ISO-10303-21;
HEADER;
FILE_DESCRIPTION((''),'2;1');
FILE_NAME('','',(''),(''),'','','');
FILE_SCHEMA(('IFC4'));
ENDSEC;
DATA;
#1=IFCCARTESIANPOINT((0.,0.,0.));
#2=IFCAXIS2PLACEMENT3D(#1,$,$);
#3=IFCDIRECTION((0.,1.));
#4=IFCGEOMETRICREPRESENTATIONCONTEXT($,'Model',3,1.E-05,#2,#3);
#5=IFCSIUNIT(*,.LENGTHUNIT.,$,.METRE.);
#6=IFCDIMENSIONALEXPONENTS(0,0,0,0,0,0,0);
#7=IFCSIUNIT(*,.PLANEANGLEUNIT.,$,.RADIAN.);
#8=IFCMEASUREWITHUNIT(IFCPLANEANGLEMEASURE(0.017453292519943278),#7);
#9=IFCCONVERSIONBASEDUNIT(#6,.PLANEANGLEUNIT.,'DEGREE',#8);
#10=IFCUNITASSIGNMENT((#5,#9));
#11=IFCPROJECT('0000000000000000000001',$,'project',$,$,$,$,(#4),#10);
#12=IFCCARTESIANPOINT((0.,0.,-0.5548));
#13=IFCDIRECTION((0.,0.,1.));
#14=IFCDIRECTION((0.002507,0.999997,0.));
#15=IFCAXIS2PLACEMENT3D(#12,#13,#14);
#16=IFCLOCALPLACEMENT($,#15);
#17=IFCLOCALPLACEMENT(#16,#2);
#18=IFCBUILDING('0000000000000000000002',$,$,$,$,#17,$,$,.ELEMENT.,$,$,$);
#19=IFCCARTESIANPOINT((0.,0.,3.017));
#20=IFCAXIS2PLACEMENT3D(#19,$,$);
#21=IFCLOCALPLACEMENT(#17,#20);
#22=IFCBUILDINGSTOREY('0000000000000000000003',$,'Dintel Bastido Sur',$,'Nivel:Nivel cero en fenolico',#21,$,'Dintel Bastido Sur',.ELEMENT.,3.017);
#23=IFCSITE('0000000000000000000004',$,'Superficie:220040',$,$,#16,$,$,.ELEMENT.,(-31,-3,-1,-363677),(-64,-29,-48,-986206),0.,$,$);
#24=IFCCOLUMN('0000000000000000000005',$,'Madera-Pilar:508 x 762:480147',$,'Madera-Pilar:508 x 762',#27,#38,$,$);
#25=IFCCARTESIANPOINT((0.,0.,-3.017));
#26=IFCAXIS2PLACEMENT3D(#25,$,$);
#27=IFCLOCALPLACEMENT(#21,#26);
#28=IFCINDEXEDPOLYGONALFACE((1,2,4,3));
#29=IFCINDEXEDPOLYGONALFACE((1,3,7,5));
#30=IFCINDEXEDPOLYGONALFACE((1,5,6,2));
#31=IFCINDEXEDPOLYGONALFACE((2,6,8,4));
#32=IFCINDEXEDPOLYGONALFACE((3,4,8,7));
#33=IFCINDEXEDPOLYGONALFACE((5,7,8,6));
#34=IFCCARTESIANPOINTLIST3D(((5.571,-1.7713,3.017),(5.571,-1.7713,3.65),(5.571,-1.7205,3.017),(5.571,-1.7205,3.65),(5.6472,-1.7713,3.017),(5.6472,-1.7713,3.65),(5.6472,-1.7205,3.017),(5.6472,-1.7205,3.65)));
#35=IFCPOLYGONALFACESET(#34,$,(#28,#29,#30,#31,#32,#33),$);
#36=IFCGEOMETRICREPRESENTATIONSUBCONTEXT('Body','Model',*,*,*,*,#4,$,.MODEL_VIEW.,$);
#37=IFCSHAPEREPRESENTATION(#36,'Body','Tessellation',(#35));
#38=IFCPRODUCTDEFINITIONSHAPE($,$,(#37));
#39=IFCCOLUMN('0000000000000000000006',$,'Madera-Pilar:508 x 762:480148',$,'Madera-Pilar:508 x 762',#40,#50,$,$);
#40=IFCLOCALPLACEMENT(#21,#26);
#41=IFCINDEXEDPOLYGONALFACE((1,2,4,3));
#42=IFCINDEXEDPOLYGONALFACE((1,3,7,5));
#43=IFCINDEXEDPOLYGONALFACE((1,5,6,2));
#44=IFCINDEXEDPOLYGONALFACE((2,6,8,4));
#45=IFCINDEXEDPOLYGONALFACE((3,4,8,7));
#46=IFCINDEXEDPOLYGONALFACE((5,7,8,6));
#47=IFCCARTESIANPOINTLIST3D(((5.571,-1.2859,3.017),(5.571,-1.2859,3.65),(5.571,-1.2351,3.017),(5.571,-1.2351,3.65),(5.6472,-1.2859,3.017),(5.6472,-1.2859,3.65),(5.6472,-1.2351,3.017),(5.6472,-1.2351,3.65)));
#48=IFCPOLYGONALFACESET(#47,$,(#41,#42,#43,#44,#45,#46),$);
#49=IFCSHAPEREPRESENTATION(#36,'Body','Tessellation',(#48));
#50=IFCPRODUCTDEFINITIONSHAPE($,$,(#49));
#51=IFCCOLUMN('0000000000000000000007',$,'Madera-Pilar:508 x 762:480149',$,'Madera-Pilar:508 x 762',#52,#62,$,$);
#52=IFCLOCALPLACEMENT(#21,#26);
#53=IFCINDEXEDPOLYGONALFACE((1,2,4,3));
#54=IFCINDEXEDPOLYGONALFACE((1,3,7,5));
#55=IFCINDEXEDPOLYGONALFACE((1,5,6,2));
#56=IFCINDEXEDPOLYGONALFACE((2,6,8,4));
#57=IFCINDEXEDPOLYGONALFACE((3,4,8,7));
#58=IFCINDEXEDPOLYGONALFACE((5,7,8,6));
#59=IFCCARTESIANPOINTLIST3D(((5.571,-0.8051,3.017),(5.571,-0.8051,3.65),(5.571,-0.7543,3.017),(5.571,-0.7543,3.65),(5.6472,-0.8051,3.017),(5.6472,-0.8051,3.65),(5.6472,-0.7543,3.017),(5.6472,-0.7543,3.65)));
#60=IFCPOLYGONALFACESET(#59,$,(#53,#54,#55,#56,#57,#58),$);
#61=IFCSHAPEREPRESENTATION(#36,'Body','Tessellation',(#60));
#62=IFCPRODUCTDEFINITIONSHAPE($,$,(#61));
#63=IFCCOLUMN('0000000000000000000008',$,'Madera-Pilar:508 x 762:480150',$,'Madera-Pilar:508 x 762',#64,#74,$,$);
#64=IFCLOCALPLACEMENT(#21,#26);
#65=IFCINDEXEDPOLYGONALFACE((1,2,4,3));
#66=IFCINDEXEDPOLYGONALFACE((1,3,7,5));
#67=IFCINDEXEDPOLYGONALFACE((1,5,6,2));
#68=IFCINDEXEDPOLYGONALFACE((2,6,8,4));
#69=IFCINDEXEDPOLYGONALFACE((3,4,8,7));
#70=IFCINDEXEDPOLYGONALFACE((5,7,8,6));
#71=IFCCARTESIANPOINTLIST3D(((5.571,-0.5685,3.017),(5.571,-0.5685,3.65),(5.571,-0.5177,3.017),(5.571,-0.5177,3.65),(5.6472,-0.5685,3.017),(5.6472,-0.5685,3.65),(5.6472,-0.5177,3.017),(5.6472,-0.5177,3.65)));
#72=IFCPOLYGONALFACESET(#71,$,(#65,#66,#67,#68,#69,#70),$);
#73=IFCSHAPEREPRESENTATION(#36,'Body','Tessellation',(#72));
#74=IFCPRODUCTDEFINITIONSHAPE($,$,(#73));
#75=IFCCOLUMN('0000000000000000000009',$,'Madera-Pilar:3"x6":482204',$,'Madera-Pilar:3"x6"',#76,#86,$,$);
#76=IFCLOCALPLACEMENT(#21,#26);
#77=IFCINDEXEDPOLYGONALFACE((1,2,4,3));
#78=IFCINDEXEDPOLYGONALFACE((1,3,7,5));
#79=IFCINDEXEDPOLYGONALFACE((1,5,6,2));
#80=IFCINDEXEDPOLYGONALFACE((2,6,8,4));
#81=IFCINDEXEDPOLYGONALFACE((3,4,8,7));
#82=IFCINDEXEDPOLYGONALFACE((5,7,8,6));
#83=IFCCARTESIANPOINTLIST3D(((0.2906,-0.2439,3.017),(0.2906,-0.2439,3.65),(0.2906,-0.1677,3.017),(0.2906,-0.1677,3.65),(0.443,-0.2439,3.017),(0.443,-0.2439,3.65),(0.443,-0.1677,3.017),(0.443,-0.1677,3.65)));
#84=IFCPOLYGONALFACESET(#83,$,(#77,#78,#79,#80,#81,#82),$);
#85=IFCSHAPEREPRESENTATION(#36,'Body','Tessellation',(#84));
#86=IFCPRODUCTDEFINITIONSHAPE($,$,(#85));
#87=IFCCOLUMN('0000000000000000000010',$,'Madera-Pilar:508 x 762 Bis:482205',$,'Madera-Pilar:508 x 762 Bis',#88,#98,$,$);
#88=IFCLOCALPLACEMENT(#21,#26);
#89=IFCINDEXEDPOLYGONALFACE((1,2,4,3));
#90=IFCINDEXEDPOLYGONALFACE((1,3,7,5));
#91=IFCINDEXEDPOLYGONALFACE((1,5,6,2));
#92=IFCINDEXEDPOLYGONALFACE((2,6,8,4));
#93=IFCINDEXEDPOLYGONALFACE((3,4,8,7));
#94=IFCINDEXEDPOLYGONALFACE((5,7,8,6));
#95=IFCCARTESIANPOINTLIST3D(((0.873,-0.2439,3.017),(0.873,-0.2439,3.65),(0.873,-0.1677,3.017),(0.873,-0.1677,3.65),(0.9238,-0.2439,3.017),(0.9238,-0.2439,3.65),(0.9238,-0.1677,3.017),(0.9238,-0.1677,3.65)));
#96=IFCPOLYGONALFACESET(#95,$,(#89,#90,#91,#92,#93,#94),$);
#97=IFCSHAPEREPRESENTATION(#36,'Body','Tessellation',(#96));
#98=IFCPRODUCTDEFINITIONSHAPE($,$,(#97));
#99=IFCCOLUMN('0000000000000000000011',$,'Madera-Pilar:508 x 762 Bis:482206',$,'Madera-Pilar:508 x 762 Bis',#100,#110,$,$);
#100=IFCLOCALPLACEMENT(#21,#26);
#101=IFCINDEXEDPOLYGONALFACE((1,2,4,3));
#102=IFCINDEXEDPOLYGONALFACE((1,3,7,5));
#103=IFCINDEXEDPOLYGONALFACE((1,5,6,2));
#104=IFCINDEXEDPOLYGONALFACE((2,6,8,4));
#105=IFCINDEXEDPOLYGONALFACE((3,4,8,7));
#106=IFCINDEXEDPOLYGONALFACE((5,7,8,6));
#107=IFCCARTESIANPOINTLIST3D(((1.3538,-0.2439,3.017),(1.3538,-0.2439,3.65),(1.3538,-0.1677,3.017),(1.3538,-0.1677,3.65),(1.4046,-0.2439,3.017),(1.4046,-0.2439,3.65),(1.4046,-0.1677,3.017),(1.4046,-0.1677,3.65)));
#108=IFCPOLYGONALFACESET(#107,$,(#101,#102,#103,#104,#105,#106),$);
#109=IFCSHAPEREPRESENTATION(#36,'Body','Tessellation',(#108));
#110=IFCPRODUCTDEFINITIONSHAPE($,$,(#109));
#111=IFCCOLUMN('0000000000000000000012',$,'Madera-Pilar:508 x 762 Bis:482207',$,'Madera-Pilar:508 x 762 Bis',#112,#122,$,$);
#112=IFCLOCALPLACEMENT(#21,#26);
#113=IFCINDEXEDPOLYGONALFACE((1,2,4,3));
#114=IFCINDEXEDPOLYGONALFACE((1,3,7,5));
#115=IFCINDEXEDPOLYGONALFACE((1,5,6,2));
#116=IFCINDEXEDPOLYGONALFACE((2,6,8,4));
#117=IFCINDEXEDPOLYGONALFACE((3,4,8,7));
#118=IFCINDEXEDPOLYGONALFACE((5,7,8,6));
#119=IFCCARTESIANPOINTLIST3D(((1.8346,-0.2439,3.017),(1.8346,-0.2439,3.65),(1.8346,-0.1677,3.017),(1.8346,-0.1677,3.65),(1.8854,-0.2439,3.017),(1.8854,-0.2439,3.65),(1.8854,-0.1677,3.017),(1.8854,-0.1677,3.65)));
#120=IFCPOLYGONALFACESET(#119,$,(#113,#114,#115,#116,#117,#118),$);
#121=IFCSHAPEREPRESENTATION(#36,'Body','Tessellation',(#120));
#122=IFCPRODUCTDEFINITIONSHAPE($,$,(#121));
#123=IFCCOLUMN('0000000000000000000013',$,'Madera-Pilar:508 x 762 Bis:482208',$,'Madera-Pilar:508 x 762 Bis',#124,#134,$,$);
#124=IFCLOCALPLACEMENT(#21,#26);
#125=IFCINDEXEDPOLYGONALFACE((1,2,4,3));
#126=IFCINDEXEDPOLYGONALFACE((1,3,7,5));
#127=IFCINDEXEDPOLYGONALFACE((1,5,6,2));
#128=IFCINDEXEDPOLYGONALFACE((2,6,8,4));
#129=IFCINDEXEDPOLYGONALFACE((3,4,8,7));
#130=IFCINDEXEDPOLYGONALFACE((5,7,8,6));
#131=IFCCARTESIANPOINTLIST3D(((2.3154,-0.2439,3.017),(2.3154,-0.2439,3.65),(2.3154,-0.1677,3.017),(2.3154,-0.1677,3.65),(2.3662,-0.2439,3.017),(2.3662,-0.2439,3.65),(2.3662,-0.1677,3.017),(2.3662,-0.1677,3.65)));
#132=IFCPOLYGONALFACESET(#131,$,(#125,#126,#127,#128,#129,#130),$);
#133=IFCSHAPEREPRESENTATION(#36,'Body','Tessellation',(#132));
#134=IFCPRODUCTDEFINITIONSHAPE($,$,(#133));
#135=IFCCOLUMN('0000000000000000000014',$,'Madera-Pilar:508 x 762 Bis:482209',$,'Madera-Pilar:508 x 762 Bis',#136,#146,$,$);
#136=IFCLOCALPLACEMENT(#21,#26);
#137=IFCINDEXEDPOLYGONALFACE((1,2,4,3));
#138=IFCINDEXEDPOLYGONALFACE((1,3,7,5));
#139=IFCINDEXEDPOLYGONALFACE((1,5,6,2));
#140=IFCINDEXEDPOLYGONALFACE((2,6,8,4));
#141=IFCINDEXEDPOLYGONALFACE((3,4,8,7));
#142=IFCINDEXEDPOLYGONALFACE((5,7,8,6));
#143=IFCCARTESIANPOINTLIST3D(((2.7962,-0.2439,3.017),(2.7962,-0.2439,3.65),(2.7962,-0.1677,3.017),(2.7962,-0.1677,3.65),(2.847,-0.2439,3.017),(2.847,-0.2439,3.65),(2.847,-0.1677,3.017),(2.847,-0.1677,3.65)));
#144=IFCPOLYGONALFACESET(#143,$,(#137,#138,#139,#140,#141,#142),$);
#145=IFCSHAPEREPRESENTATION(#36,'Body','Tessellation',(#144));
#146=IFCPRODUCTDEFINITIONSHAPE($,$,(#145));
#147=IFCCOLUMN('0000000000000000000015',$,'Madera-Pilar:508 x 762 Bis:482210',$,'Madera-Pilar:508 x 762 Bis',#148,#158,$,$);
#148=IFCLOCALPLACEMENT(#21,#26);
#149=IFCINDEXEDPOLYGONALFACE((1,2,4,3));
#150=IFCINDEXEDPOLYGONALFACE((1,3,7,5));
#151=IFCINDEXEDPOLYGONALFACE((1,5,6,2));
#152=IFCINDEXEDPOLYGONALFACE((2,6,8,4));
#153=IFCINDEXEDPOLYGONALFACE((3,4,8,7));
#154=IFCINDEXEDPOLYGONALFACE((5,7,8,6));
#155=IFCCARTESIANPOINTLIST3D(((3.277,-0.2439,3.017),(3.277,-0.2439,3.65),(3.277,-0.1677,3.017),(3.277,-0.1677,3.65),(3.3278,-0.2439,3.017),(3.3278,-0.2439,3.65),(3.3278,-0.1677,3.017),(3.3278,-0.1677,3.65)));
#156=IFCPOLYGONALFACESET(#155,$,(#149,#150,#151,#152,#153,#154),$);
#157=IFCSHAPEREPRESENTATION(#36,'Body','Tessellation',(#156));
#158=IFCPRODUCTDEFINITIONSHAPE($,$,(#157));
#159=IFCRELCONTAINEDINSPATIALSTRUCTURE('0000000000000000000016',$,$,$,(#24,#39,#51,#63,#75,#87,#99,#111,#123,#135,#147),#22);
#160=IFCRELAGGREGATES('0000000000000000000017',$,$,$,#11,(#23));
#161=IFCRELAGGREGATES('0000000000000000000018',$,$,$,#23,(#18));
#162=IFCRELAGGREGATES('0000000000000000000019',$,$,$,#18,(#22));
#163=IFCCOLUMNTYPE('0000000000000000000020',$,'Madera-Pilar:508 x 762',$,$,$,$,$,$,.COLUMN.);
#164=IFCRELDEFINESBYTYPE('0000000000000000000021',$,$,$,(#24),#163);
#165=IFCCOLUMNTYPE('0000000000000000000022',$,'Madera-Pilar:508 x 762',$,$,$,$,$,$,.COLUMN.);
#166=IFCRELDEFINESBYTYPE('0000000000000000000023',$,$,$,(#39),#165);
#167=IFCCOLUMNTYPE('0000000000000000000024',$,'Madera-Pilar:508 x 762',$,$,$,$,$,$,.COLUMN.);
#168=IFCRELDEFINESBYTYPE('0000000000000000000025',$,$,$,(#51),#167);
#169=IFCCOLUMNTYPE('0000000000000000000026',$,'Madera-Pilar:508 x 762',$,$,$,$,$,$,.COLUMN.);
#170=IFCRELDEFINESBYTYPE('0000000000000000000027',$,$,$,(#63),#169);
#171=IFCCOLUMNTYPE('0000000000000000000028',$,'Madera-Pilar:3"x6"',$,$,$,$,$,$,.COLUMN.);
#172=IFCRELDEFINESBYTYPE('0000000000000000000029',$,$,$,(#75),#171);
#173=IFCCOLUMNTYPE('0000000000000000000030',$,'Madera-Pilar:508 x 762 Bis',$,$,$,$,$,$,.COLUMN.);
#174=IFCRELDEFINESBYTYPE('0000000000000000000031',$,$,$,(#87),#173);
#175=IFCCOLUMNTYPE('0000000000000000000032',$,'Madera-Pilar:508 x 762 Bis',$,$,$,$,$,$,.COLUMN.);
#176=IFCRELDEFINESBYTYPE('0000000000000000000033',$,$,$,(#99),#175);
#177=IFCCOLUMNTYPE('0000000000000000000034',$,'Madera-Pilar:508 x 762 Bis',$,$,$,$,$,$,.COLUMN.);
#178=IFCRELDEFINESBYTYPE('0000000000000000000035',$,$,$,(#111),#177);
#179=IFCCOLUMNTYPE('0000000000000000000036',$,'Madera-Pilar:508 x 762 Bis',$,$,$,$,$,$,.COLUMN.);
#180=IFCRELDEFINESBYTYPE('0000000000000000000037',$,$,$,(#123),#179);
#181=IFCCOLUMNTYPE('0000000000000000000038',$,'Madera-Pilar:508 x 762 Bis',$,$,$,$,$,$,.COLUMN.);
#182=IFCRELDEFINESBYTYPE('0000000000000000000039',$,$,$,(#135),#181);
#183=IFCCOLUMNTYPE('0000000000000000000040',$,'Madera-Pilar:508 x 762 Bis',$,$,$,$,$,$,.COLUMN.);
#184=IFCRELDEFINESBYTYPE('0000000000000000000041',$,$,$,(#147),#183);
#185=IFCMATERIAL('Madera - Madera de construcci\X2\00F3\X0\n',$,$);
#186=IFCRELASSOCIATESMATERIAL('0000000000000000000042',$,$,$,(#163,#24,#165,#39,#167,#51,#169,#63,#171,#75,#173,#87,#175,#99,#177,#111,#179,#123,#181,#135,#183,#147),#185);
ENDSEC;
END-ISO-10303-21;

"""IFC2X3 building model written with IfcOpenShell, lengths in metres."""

from ifc_helpers import new_model, entity, si_unit, converted_unit, direction, frame, frame_2d, origin, origin_2d_with_axis, place, context, subcontext, project, spatial, rectangle, extrude, source, transform, mapped, material, type_object, type_shapes, element, save


model = new_model("IFC2X3")

# Units and contexts
model_context = context("Model", 3, precision=1e-05, world=origin(), true_north=direction((0.0, 1.0)))
body_context = subcontext(model_context, "Body", "Model", "MODEL_VIEW")
ifc_project = project(units=[si_unit("LENGTHUNIT", "METRE"), converted_unit("PLANEANGLEUNIT", "DEGREE", entity("IfcPlaneAngleMeasure", 0.017453292519943278), si_unit("PLANEANGLEUNIT", "RADIAN"), dimensions=[0, 0, 0, 0, 0, 0, 0])], contexts=[model_context])

# Site, building, storey
site_placement = place(None, frame((0.0, 0.0, -0.5548), z_axis=(0.0, 0.0, 1.0), x_axis=(0.002507, 0.999997, 0.0)))
site = spatial("IfcSite", under=ifc_project, at=site_placement, Name="Superficie:220040", CompositionType="ELEMENT", RefLatitude=(-31, -3, -1, -363677), RefLongitude=(-64, -29, -48, -986206), RefElevation=0.0)
building_placement = place(site_placement, origin())
building = spatial("IfcBuilding", under=site, at=building_placement, CompositionType="ELEMENT")
storey_placement = place(building_placement, frame((0.0, 0.0, 3.017)))
storey = spatial("IfcBuildingStorey", under=building, at=storey_placement, Name="Dintel Bastido Sur", ObjectType="Nivel:Nivel cero en fenolico", LongName="Dintel Bastido Sur", CompositionType="ELEMENT", Elevation=3.017)

# Columns
ifc_material_1 = material(Name="Madera - Madera de construcción")
column_type_1 = type_object("IfcColumnType", Name="Madera-Pilar:508 x 762", PredefinedType="COLUMN", material=ifc_material_1)
shared_shape_1 = source(origin(), body_context, "Body", "SweptSolid", [
    extrude(rectangle(XDim=0.0762, YDim=0.0508, at=origin_2d_with_axis()), frame((5.6091, -1.7459, 3.017), z_axis=(0.0, 0.0, 1.0), x_axis=(-1.0, 0.0, 0.0)), (0.0, 0.0, 1.0), 0.633),
])
type_shapes(column_type_1, [shared_shape_1])
column_1_placement = place(storey_placement, frame((0.0, 0.0, -3.017)))
element("IfcColumn", 1, at=column_1_placement, inside=storey, type_object=column_type_1, material=ifc_material_1, Name="Madera-Pilar:508 x 762:480147", ObjectType="Madera-Pilar:508 x 762", context=body_context, shape_type="MappedRepresentation", body=[
    mapped(shared_shape_1, transform((0.0, 0.0, 0.0), scale=1.0)),
])
column_type_2 = type_object("IfcColumnType", Name="Madera-Pilar:508 x 762", PredefinedType="COLUMN", material=ifc_material_1)
shared_shape_2 = source(origin(), body_context, "Body", "SweptSolid", [
    extrude(rectangle(XDim=0.0762, YDim=0.0508, at=origin_2d_with_axis()), frame((5.6091, -1.2605, 3.017), z_axis=(0.0, 0.0, 1.0), x_axis=(-1.0, 0.0, 0.0)), (0.0, 0.0, 1.0), 0.633),
])
type_shapes(column_type_2, [shared_shape_2])
column_2_placement = place(storey_placement, frame((0.0, 0.0, -3.017)))
element("IfcColumn", 2, at=column_2_placement, inside=storey, type_object=column_type_2, material=ifc_material_1, Name="Madera-Pilar:508 x 762:480148", ObjectType="Madera-Pilar:508 x 762", context=body_context, shape_type="MappedRepresentation", body=[
    mapped(shared_shape_2, transform((0.0, 0.0, 0.0), scale=1.0)),
])
column_type_3 = type_object("IfcColumnType", Name="Madera-Pilar:508 x 762", PredefinedType="COLUMN", material=ifc_material_1)
shared_shape_3 = source(origin(), body_context, "Body", "SweptSolid", [
    extrude(rectangle(XDim=0.0762, YDim=0.0508, at=frame_2d((0.0, 0.0), x_axis=(1.0, 0.0))), frame((5.6091, -0.7797, 3.017), z_axis=(0.0, 0.0, 1.0), x_axis=(-1.0, 0.0, 0.0)), (0.0, 0.0, 1.0), 0.633),
])
type_shapes(column_type_3, [shared_shape_3])
column_3_placement = place(storey_placement, frame((0.0, 0.0, -3.017)))
element("IfcColumn", 3, at=column_3_placement, inside=storey, type_object=column_type_3, material=ifc_material_1, Name="Madera-Pilar:508 x 762:480149", ObjectType="Madera-Pilar:508 x 762", context=body_context, shape_type="MappedRepresentation", body=[
    mapped(shared_shape_3, transform((0.0, 0.0, 0.0), scale=1.0)),
])
column_type_4 = type_object("IfcColumnType", Name="Madera-Pilar:508 x 762", PredefinedType="COLUMN", material=ifc_material_1)
shared_shape_4 = source(origin(), body_context, "Body", "SweptSolid", [
    extrude(rectangle(XDim=0.0762, YDim=0.0508, at=origin_2d_with_axis()), frame((5.6091, -0.5431, 3.017), z_axis=(0.0, 0.0, 1.0), x_axis=(-1.0, 0.0, 0.0)), (0.0, 0.0, 1.0), 0.633),
])
type_shapes(column_type_4, [shared_shape_4])
column_4_placement = place(storey_placement, frame((0.0, 0.0, -3.017)))
element("IfcColumn", 4, at=column_4_placement, inside=storey, type_object=column_type_4, material=ifc_material_1, Name="Madera-Pilar:508 x 762:480150", ObjectType="Madera-Pilar:508 x 762", context=body_context, shape_type="MappedRepresentation", body=[
    mapped(shared_shape_4, transform((0.0, 0.0, 0.0), scale=1.0)),
])
column_type_5 = type_object("IfcColumnType", Name="Madera-Pilar:3\"x6\"", PredefinedType="COLUMN", material=ifc_material_1)
shared_shape_5 = source(origin(), body_context, "Body", "SweptSolid", [
    extrude(rectangle(XDim=0.1524, YDim=0.0762, at=frame_2d((0.0, 0.0), x_axis=(1.0, 0.0))), frame((0.3668, -0.2058, 3.017), z_axis=(0.0, 0.0, 1.0), x_axis=(-1.0, 0.0, 0.0)), (0.0, 0.0, 1.0), 0.633),
])
type_shapes(column_type_5, [shared_shape_5])
column_5_placement = place(storey_placement, frame((0.0, 0.0, -3.017)))
element("IfcColumn", 5, at=column_5_placement, inside=storey, type_object=column_type_5, material=ifc_material_1, Name="Madera-Pilar:3\"x6\":482204", ObjectType="Madera-Pilar:3\"x6\"", context=body_context, shape_type="MappedRepresentation", body=[
    mapped(shared_shape_5, transform((0.0, 0.0, 0.0), scale=1.0)),
])
column_type_6 = type_object("IfcColumnType", Name="Madera-Pilar:508 x 762 Bis", PredefinedType="COLUMN", material=ifc_material_1)
shared_shape_6 = source(origin(), body_context, "Body", "SweptSolid", [
    extrude(rectangle(XDim=0.0508, YDim=0.0762, at=frame_2d((0.0, 0.0), x_axis=(1.0, 0.0))), frame((0.8984, -0.2058, 3.017), z_axis=(0.0, 0.0, 1.0), x_axis=(-1.0, 0.0, 0.0)), (0.0, 0.0, 1.0), 0.633),
])
type_shapes(column_type_6, [shared_shape_6])
column_6_placement = place(storey_placement, frame((0.0, 0.0, -3.017)))
element("IfcColumn", 6, at=column_6_placement, inside=storey, type_object=column_type_6, material=ifc_material_1, Name="Madera-Pilar:508 x 762 Bis:482205", ObjectType="Madera-Pilar:508 x 762 Bis", context=body_context, shape_type="MappedRepresentation", body=[
    mapped(shared_shape_6, transform((0.0, 0.0, 0.0), scale=1.0)),
])
column_type_7 = type_object("IfcColumnType", Name="Madera-Pilar:508 x 762 Bis", PredefinedType="COLUMN", material=ifc_material_1)
shared_shape_7 = source(origin(), body_context, "Body", "SweptSolid", [
    extrude(rectangle(XDim=0.0508, YDim=0.0762, at=frame_2d((0.0, 0.0), x_axis=(1.0, 0.0))), frame((1.3792, -0.2058, 3.017), z_axis=(0.0, 0.0, 1.0), x_axis=(-1.0, 0.0, 0.0)), (0.0, 0.0, 1.0), 0.633),
])
type_shapes(column_type_7, [shared_shape_7])
column_7_placement = place(storey_placement, frame((0.0, 0.0, -3.017)))
element("IfcColumn", 7, at=column_7_placement, inside=storey, type_object=column_type_7, material=ifc_material_1, Name="Madera-Pilar:508 x 762 Bis:482206", ObjectType="Madera-Pilar:508 x 762 Bis", context=body_context, shape_type="MappedRepresentation", body=[
    mapped(shared_shape_7, transform((0.0, 0.0, 0.0), scale=1.0)),
])
column_type_8 = type_object("IfcColumnType", Name="Madera-Pilar:508 x 762 Bis", PredefinedType="COLUMN", material=ifc_material_1)
shared_shape_8 = source(origin(), body_context, "Body", "SweptSolid", [
    extrude(rectangle(XDim=0.0508, YDim=0.0762, at=frame_2d((0.0, 0.0), x_axis=(1.0, 0.0))), frame((1.86, -0.2058, 3.017), z_axis=(0.0, 0.0, 1.0), x_axis=(-1.0, 0.0, 0.0)), (0.0, 0.0, 1.0), 0.633),
])
type_shapes(column_type_8, [shared_shape_8])
column_8_placement = place(storey_placement, frame((0.0, 0.0, -3.017)))
element("IfcColumn", 8, at=column_8_placement, inside=storey, type_object=column_type_8, material=ifc_material_1, Name="Madera-Pilar:508 x 762 Bis:482207", ObjectType="Madera-Pilar:508 x 762 Bis", context=body_context, shape_type="MappedRepresentation", body=[
    mapped(shared_shape_8, transform((0.0, 0.0, 0.0), scale=1.0)),
])
column_type_9 = type_object("IfcColumnType", Name="Madera-Pilar:508 x 762 Bis", PredefinedType="COLUMN", material=ifc_material_1)
shared_shape_9 = source(origin(), body_context, "Body", "SweptSolid", [
    extrude(rectangle(XDim=0.0508, YDim=0.0762, at=frame_2d((0.0, 0.0), x_axis=(1.0, 0.0))), frame((2.3408, -0.2058, 3.017), z_axis=(0.0, 0.0, 1.0), x_axis=(-1.0, 0.0, 0.0)), (0.0, 0.0, 1.0), 0.633),
])
type_shapes(column_type_9, [shared_shape_9])
column_9_placement = place(storey_placement, frame((0.0, 0.0, -3.017)))
element("IfcColumn", 9, at=column_9_placement, inside=storey, type_object=column_type_9, material=ifc_material_1, Name="Madera-Pilar:508 x 762 Bis:482208", ObjectType="Madera-Pilar:508 x 762 Bis", context=body_context, shape_type="MappedRepresentation", body=[
    mapped(shared_shape_9, transform((0.0, 0.0, 0.0), scale=1.0)),
])
column_type_10 = type_object("IfcColumnType", Name="Madera-Pilar:508 x 762 Bis", PredefinedType="COLUMN", material=ifc_material_1)
shared_shape_10 = source(origin(), body_context, "Body", "SweptSolid", [
    extrude(rectangle(XDim=0.0508, YDim=0.0762, at=frame_2d((0.0, 0.0), x_axis=(1.0, 0.0))), frame((2.8216, -0.2058, 3.017), z_axis=(0.0, 0.0, 1.0), x_axis=(-1.0, 0.0, 0.0)), (0.0, 0.0, 1.0), 0.633),
])
type_shapes(column_type_10, [shared_shape_10])
column_10_placement = place(storey_placement, frame((0.0, 0.0, -3.017)))
element("IfcColumn", 10, at=column_10_placement, inside=storey, type_object=column_type_10, material=ifc_material_1, Name="Madera-Pilar:508 x 762 Bis:482209", ObjectType="Madera-Pilar:508 x 762 Bis", context=body_context, shape_type="MappedRepresentation", body=[
    mapped(shared_shape_10, transform((0.0, 0.0, 0.0), scale=1.0)),
])
column_type_11 = type_object("IfcColumnType", Name="Madera-Pilar:508 x 762 Bis", PredefinedType="COLUMN", material=ifc_material_1)
shared_shape_11 = source(origin(), body_context, "Body", "SweptSolid", [
    extrude(rectangle(XDim=0.0508, YDim=0.0762, at=frame_2d((0.0, 0.0), x_axis=(1.0, 0.0))), frame((3.3024, -0.2058, 3.017), z_axis=(0.0, 0.0, 1.0), x_axis=(-1.0, 0.0, 0.0)), (0.0, 0.0, 1.0), 0.633),
])
type_shapes(column_type_11, [shared_shape_11])
column_11_placement = place(storey_placement, frame((0.0, 0.0, -3.017)))
element("IfcColumn", 11, at=column_11_placement, inside=storey, type_object=column_type_11, material=ifc_material_1, Name="Madera-Pilar:508 x 762 Bis:482210", ObjectType="Madera-Pilar:508 x 762 Bis", context=body_context, shape_type="MappedRepresentation", body=[
    mapped(shared_shape_11, transform((0.0, 0.0, 0.0), scale=1.0)),
])

save(model, "model.ifc")
